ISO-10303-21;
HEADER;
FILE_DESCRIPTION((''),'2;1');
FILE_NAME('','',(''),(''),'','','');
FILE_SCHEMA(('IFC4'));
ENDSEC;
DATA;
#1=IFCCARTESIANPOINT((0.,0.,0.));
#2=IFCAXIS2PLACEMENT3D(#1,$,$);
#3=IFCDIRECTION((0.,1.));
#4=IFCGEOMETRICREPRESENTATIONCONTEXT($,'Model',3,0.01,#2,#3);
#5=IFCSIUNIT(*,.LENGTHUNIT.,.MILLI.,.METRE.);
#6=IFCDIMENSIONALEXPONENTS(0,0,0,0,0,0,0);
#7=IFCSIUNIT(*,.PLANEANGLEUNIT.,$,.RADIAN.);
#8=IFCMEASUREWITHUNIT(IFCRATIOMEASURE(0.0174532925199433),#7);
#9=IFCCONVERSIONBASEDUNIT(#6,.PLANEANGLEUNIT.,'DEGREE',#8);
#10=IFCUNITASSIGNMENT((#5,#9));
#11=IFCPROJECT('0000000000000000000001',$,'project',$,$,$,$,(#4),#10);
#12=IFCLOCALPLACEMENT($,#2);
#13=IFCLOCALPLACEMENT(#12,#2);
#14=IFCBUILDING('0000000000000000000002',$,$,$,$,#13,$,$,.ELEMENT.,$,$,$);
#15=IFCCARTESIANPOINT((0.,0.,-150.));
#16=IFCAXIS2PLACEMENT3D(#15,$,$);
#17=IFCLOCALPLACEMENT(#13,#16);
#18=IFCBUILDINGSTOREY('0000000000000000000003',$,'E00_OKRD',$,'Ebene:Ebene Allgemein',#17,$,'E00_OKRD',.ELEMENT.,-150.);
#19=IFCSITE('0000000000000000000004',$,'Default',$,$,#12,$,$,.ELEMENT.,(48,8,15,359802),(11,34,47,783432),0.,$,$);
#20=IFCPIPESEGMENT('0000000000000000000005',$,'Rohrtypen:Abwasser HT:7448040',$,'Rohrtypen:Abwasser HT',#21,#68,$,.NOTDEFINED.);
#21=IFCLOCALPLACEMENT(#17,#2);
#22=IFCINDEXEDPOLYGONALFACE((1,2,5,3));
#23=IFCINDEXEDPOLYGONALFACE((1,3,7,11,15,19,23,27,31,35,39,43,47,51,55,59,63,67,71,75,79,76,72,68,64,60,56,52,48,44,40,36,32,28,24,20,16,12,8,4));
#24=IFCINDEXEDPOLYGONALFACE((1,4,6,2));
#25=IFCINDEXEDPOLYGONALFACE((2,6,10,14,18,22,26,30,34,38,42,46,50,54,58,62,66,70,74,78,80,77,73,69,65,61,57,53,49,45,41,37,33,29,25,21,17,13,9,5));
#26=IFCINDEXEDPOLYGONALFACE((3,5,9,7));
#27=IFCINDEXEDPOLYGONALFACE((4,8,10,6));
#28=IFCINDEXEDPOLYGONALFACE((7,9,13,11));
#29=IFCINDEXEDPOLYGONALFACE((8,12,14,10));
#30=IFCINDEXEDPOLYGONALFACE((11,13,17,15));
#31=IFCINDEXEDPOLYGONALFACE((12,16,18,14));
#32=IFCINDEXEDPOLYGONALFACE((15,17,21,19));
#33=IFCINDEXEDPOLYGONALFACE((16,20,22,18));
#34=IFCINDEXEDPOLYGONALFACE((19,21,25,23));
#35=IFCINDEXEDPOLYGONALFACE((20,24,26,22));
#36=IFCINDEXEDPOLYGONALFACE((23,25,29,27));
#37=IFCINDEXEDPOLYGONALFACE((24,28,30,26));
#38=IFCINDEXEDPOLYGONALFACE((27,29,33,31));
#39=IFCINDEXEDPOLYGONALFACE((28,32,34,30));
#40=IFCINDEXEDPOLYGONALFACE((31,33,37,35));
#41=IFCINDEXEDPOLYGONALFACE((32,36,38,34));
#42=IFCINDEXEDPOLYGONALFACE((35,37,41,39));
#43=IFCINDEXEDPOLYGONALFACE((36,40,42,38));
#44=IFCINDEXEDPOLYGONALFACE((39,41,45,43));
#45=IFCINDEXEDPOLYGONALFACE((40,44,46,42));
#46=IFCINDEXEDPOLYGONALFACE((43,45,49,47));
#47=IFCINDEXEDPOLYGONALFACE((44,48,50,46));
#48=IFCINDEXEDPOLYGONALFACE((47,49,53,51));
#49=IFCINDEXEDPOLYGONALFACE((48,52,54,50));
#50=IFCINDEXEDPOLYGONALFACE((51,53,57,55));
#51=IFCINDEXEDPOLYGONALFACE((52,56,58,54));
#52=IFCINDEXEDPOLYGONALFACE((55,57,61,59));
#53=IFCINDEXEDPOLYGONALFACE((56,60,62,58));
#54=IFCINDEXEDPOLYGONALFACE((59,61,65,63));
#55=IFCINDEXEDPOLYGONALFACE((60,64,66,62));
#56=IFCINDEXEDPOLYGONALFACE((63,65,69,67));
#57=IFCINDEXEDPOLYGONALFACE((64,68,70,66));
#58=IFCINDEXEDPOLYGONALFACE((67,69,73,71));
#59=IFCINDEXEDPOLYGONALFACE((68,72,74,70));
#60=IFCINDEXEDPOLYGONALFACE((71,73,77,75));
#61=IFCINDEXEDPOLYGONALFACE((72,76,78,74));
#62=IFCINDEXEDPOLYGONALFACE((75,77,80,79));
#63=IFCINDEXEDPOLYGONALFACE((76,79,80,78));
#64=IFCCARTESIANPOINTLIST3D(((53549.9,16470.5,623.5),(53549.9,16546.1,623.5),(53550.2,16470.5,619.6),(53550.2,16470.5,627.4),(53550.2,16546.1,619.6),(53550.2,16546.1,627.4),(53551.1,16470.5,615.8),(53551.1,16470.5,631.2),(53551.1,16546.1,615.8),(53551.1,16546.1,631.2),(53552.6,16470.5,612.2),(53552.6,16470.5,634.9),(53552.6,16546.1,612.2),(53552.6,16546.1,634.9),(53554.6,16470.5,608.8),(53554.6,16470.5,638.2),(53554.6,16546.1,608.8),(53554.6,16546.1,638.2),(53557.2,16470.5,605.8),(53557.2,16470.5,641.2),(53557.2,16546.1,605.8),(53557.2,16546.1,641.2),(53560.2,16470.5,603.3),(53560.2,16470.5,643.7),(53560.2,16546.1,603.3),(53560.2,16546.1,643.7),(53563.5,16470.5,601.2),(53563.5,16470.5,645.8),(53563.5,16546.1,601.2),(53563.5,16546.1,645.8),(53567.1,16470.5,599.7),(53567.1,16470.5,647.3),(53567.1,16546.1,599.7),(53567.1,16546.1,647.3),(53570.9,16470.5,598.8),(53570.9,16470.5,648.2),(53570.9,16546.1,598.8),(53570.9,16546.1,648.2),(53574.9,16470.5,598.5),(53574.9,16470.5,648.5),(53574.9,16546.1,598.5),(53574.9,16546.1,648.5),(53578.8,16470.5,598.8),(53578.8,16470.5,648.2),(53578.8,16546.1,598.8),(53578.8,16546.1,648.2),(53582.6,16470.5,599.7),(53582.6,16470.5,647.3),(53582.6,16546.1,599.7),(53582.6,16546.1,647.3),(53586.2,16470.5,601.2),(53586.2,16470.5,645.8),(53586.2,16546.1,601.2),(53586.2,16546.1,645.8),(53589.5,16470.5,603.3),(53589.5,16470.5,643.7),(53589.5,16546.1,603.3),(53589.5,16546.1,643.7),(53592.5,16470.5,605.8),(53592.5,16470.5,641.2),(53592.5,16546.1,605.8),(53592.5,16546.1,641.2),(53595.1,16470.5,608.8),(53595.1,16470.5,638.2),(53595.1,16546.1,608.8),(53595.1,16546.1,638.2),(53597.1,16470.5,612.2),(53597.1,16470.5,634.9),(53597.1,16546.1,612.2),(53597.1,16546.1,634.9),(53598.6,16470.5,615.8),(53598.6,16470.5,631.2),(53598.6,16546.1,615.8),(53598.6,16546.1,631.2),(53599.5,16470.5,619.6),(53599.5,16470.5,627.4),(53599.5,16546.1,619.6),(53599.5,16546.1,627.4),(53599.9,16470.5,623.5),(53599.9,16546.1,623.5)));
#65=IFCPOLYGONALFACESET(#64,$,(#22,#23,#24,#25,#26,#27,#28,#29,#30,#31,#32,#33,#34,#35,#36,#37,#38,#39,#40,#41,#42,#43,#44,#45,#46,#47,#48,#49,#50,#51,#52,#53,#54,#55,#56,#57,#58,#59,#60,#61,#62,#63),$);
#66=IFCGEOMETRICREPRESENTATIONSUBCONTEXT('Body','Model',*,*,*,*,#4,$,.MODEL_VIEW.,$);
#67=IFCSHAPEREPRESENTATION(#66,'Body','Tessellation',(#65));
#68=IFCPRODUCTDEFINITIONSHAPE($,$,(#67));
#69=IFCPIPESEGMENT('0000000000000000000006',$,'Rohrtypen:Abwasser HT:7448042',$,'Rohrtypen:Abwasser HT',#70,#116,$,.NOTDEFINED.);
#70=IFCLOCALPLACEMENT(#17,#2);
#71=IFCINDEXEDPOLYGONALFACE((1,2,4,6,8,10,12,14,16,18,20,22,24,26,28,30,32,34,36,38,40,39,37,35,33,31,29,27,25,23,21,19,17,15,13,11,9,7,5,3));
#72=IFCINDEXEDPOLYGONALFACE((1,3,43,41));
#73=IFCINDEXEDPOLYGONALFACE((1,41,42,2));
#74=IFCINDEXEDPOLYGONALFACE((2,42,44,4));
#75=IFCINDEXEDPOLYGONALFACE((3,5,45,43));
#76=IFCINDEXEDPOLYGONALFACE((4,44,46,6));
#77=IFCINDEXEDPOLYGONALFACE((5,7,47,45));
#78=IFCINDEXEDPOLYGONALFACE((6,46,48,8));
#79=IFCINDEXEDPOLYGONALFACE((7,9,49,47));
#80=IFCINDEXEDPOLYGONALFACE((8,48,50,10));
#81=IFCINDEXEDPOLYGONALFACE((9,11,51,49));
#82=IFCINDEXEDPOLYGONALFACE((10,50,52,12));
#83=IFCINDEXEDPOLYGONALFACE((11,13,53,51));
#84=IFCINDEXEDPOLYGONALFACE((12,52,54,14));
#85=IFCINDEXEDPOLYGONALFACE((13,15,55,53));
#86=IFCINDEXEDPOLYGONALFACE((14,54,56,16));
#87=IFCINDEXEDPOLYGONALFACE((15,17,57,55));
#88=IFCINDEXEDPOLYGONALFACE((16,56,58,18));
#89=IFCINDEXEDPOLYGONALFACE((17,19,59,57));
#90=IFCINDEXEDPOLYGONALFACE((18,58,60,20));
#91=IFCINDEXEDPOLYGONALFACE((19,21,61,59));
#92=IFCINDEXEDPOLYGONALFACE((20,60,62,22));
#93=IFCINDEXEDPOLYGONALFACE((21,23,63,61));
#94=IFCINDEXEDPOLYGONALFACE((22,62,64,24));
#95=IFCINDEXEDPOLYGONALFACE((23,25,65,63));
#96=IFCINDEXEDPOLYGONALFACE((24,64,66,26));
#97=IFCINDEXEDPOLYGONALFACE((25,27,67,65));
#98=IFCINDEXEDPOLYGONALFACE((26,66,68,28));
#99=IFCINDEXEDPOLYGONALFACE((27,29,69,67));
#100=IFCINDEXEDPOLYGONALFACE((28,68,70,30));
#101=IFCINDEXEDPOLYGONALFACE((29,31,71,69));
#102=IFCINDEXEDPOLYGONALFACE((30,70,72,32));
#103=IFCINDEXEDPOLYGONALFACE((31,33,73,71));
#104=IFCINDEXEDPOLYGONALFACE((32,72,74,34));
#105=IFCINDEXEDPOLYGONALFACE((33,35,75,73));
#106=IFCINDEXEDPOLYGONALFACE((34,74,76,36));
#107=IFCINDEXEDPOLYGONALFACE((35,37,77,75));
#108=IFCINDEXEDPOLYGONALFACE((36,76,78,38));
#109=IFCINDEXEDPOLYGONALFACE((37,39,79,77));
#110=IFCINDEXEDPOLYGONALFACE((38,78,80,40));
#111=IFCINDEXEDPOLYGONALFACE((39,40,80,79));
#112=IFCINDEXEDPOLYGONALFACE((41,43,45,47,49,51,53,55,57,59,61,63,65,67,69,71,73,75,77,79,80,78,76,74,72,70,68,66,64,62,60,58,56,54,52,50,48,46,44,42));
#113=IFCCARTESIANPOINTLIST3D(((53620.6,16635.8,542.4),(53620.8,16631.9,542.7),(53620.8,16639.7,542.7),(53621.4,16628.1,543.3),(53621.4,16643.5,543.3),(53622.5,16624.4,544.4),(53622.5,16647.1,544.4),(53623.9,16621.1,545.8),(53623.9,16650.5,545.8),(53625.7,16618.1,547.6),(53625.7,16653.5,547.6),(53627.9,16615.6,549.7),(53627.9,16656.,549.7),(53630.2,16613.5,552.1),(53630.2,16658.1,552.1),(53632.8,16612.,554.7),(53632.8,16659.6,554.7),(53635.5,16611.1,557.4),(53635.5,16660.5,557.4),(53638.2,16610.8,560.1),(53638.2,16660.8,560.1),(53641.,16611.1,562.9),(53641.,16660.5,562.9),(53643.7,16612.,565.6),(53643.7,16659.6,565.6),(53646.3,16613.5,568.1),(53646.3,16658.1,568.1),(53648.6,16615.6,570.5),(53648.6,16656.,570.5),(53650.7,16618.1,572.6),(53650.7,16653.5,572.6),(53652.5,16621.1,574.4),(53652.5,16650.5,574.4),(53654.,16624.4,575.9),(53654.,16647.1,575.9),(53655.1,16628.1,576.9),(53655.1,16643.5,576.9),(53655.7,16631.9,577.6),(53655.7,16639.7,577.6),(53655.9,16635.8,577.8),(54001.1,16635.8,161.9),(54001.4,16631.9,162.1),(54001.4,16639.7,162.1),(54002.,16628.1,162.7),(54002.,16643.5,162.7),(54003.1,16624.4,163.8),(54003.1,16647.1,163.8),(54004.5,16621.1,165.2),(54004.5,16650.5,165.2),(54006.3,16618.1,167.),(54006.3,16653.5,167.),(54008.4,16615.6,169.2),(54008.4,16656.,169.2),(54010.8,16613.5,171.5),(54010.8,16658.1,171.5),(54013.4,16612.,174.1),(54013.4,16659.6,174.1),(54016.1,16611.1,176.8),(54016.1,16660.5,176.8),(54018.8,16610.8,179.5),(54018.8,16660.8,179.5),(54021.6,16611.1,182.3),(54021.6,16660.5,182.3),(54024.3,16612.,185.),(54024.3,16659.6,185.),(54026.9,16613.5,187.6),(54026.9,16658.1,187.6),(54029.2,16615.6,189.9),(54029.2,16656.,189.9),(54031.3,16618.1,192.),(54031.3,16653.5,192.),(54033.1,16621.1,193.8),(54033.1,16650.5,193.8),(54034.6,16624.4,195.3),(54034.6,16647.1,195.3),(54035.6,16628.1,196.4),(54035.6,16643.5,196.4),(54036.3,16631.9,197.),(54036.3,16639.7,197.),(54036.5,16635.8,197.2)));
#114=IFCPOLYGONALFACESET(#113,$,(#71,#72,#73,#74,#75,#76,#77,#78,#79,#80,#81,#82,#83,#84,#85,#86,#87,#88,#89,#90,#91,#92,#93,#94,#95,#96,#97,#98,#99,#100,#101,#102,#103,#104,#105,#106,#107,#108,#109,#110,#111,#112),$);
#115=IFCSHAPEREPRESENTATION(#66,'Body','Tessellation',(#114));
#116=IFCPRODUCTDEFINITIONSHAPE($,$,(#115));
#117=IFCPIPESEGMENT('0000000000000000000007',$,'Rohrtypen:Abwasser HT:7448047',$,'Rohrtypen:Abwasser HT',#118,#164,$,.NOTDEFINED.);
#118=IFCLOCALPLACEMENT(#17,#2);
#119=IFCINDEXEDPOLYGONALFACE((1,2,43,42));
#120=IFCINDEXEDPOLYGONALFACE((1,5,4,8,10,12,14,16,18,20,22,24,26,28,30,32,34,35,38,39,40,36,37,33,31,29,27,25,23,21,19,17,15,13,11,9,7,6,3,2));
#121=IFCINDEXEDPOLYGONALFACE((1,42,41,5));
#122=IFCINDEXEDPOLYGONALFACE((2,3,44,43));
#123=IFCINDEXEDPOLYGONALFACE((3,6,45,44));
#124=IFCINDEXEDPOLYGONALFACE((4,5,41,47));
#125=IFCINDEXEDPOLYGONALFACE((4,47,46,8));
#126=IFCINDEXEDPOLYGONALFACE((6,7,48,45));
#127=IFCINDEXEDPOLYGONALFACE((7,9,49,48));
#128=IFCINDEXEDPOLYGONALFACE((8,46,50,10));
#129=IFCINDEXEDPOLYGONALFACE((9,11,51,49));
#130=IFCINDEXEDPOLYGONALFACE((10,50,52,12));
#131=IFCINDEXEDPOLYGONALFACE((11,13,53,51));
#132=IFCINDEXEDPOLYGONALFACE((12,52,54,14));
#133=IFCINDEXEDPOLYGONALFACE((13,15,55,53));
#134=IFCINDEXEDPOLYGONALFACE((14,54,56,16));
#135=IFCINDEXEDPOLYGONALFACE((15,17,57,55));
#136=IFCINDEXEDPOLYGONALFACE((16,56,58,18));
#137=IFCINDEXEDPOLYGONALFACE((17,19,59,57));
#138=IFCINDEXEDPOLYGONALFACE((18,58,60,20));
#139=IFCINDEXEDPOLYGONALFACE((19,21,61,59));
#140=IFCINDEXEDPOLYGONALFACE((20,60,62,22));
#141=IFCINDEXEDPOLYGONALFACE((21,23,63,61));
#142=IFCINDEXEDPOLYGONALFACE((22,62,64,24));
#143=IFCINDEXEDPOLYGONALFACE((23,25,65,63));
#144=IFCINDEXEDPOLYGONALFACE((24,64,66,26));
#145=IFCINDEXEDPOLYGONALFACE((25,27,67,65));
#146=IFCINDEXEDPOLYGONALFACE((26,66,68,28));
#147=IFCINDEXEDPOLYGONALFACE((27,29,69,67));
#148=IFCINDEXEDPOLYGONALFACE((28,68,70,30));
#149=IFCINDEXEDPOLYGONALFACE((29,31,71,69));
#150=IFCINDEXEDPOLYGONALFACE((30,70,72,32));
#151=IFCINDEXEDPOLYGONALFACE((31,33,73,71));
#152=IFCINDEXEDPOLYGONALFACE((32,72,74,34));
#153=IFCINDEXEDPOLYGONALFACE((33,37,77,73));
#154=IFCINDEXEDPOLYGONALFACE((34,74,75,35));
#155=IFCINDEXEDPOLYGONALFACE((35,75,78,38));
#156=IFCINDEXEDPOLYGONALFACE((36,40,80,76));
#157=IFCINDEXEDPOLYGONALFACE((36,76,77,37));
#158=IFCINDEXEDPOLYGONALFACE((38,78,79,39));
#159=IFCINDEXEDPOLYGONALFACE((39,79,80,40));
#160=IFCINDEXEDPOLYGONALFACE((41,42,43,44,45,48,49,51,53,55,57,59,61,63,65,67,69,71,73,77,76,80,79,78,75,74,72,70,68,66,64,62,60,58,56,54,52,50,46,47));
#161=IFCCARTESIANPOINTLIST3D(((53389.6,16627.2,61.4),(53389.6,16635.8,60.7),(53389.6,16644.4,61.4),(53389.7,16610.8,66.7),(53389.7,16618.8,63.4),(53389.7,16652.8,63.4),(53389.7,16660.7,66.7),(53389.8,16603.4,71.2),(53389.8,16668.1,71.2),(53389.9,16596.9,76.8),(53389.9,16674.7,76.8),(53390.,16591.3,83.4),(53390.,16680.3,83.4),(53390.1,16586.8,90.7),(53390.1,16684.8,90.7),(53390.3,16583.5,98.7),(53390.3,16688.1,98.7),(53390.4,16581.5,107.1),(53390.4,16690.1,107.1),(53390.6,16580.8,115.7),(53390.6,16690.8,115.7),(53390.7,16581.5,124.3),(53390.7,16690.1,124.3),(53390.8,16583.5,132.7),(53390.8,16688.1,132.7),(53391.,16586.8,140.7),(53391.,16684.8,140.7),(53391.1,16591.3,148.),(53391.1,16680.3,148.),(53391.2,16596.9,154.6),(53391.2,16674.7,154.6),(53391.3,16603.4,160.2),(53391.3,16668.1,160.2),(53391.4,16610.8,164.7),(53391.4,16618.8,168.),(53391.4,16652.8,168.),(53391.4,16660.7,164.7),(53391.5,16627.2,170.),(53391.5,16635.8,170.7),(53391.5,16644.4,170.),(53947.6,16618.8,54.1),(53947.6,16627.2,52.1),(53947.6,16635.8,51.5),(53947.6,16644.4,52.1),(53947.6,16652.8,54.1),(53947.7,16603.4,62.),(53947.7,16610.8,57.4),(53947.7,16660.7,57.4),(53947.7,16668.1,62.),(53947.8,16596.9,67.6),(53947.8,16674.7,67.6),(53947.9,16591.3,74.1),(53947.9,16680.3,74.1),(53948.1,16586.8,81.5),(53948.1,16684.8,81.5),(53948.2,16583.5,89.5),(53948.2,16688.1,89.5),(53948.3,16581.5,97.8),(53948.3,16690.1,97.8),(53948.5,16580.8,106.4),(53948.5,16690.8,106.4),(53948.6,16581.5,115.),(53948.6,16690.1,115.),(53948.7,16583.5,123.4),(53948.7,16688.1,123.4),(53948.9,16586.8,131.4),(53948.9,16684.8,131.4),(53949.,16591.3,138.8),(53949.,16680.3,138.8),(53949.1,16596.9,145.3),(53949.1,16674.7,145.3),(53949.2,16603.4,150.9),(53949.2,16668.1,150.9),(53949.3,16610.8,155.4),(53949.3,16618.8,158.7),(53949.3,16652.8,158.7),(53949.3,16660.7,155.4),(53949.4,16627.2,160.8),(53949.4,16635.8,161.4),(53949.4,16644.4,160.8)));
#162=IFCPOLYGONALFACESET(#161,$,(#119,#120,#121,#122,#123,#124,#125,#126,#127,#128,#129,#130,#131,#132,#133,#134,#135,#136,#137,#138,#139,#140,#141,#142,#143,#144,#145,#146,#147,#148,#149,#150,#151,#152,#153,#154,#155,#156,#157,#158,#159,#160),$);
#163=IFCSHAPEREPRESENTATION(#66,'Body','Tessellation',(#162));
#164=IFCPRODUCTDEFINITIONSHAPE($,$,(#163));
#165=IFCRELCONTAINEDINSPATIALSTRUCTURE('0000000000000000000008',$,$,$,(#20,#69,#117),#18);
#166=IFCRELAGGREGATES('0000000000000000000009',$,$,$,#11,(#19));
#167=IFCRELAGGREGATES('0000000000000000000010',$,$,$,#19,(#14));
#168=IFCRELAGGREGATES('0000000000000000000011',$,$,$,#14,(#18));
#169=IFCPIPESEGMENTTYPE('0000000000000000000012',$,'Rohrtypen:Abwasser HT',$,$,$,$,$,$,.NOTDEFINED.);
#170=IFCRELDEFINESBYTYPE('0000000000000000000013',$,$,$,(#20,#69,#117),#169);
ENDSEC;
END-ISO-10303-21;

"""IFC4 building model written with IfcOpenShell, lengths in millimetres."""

from ifc_helpers import new_model, entity, si_unit, converted_unit, direction, frame, origin, place, context, subcontext, project, spatial, indexed_curve, outline, extrude, type_object, element, save


model = new_model("IFC4")

# Units and contexts
model_context = context("Model", 3, precision=0.01, world=origin(), true_north=direction((0.0, 1.0)))
body_context = subcontext(model_context, "Body", "Model", "MODEL_VIEW")
ifc_project = project(units=[si_unit("LENGTHUNIT", "METRE", prefix="MILLI"), converted_unit("PLANEANGLEUNIT", "DEGREE", entity("IfcRatioMeasure", 0.0174532925199433), si_unit("PLANEANGLEUNIT", "RADIAN"), dimensions=[0, 0, 0, 0, 0, 0, 0])], contexts=[model_context])

# Site, building, storey
site_placement = place(None, origin())
site = spatial("IfcSite", under=ifc_project, at=site_placement, Name="Default", CompositionType="ELEMENT", RefLatitude=(48, 8, 15, 359802), RefLongitude=(11, 34, 47, 783432), RefElevation=0.0)
building_placement = place(site_placement, origin())
building = spatial("IfcBuilding", under=site, at=building_placement, CompositionType="ELEMENT")
storey_placement = place(building_placement, frame((0.0, 0.0, -150.0)))
storey = spatial("IfcBuildingStorey", under=building, at=storey_placement, Name="E00_OKRD", ObjectType="Ebene:Ebene Allgemein", LongName="E00_OKRD", CompositionType="ELEMENT", Elevation=-150.0)

# Pipe segments
pipe_segment_type_1 = type_object("IfcPipeSegmentType", Name="Rohrtypen:Abwasser HT", PredefinedType="NOTDEFINED")
pipe_segment_1_placement = place(storey_placement, origin())
element("IfcPipeSegment", 1, at=pipe_segment_1_placement, inside=storey, type_object=pipe_segment_type_1, Name="Rohrtypen:Abwasser HT:7448040", ObjectType="Rohrtypen:Abwasser HT", PredefinedType="NOTDEFINED", context=body_context, shape_type="SweptSolid", body=[
    extrude(outline(indexed_curve([(25.0, 0.0), (24.7, 3.9), (23.8, 7.7), (22.3, 11.3), (20.2, 14.7), (17.7, 17.7), (14.7, 20.2), (11.3, 22.3), (7.7, 23.8), (3.9, 24.7), (0.0, 25.0), (-3.9, 24.7), (-7.7, 23.8), (-11.3, 22.3), (-14.7, 20.2), (-17.7, 17.7), (-20.2, 14.7), (-22.3, 11.3), (-23.8, 7.7), (-24.7, 3.9), (-25.0, 0.0), (-24.7, -3.9), (-23.8, -7.7), (-22.3, -11.3), (-20.2, -14.7), (-17.7, -17.7), (-14.7, -20.2), (-11.3, -22.3), (-7.7, -23.8), (-3.9, -24.7), (0.0, -25.0), (3.9, -24.7), (7.7, -23.8), (11.3, -22.3), (14.7, -20.2), (17.7, -17.7), (20.2, -14.7), (22.3, -11.3), (23.8, -7.7), (24.7, -3.9), (25.0, 0.0)], self_intersect=False)), frame((53574.9, 16470.5, 623.5), z_axis=(0.0, 1.0, 0.0), x_axis=(1.0, 0.0, 0.0)), (0.0, 0.0, 1.0), 75.6),
])
pipe_segment_2_placement = place(storey_placement, origin())
element("IfcPipeSegment", 2, at=pipe_segment_2_placement, inside=storey, type_object=pipe_segment_type_1, Name="Rohrtypen:Abwasser HT:7448042", ObjectType="Rohrtypen:Abwasser HT", PredefinedType="NOTDEFINED", context=body_context, shape_type="SweptSolid", body=[
    extrude(outline(indexed_curve([(25.0, 0.0), (24.7, 3.9), (23.8, 7.7), (22.3, 11.3), (20.2, 14.7), (17.7, 17.7), (14.7, 20.2), (11.3, 22.3), (7.7, 23.8), (3.9, 24.7), (0.0, 25.0), (-3.9, 24.7), (-7.7, 23.8), (-11.3, 22.3), (-14.7, 20.2), (-17.7, 17.7), (-20.2, 14.7), (-22.3, 11.3), (-23.8, 7.7), (-24.7, 3.9), (-25.0, 0.0), (-24.7, -3.9), (-23.8, -7.7), (-22.3, -11.3), (-20.2, -14.7), (-17.7, -17.7), (-14.7, -20.2), (-11.3, -22.3), (-7.7, -23.8), (-3.9, -24.7), (0.0, -25.0), (3.9, -24.7), (7.7, -23.8), (11.3, -22.3), (14.7, -20.2), (17.7, -17.7), (20.2, -14.7), (22.3, -11.3), (23.8, -7.7), (24.7, -3.9), (25.0, 0.0)], self_intersect=False)), frame((53638.2, 16635.8, 560.1), z_axis=(0.707107, 0.0, -0.707107), x_axis=(0.0, -1.0, 0.0)), (0.0, 0.0, 1.0), 538.2),
])
pipe_segment_3_placement = place(storey_placement, origin())
element("IfcPipeSegment", 3, at=pipe_segment_3_placement, inside=storey, type_object=pipe_segment_type_1, Name="Rohrtypen:Abwasser HT:7448047", ObjectType="Rohrtypen:Abwasser HT", PredefinedType="NOTDEFINED", context=body_context, shape_type="SweptSolid", body=[
    extrude(outline(indexed_curve([(55.0, 0.0), (54.3, 8.6), (52.3, 17.0), (49.0, 25.0), (44.5, 32.3), (38.9, 38.9), (32.3, 44.5), (25.0, 49.0), (17.0, 52.3), (8.6, 54.3), (0.0, 55.0), (-8.6, 54.3), (-17.0, 52.3), (-25.0, 49.0), (-32.3, 44.5), (-38.9, 38.9), (-44.5, 32.3), (-49.0, 25.0), (-52.3, 17.0), (-54.3, 8.6), (-55.0, 0.0), (-54.3, -8.6), (-52.3, -17.0), (-49.0, -25.0), (-44.5, -32.3), (-38.9, -38.9), (-32.3, -44.5), (-25.0, -49.0), (-17.0, -52.3), (-8.6, -54.3), (0.0, -55.0), (8.6, -54.3), (17.0, -52.3), (25.0, -49.0), (32.3, -44.5), (38.9, -38.9), (44.5, -32.3), (49.0, -25.0), (52.3, -17.0), (54.3, -8.6), (55.0, 0.0)], self_intersect=False)), frame((53390.6, 16635.8, 115.7), z_axis=(0.999862, 0.0, -0.016604), x_axis=(0.0, -1.0, 0.0)), (0.0, 0.0, 1.0), 558.0),
])

save(model, "model.ifc")
